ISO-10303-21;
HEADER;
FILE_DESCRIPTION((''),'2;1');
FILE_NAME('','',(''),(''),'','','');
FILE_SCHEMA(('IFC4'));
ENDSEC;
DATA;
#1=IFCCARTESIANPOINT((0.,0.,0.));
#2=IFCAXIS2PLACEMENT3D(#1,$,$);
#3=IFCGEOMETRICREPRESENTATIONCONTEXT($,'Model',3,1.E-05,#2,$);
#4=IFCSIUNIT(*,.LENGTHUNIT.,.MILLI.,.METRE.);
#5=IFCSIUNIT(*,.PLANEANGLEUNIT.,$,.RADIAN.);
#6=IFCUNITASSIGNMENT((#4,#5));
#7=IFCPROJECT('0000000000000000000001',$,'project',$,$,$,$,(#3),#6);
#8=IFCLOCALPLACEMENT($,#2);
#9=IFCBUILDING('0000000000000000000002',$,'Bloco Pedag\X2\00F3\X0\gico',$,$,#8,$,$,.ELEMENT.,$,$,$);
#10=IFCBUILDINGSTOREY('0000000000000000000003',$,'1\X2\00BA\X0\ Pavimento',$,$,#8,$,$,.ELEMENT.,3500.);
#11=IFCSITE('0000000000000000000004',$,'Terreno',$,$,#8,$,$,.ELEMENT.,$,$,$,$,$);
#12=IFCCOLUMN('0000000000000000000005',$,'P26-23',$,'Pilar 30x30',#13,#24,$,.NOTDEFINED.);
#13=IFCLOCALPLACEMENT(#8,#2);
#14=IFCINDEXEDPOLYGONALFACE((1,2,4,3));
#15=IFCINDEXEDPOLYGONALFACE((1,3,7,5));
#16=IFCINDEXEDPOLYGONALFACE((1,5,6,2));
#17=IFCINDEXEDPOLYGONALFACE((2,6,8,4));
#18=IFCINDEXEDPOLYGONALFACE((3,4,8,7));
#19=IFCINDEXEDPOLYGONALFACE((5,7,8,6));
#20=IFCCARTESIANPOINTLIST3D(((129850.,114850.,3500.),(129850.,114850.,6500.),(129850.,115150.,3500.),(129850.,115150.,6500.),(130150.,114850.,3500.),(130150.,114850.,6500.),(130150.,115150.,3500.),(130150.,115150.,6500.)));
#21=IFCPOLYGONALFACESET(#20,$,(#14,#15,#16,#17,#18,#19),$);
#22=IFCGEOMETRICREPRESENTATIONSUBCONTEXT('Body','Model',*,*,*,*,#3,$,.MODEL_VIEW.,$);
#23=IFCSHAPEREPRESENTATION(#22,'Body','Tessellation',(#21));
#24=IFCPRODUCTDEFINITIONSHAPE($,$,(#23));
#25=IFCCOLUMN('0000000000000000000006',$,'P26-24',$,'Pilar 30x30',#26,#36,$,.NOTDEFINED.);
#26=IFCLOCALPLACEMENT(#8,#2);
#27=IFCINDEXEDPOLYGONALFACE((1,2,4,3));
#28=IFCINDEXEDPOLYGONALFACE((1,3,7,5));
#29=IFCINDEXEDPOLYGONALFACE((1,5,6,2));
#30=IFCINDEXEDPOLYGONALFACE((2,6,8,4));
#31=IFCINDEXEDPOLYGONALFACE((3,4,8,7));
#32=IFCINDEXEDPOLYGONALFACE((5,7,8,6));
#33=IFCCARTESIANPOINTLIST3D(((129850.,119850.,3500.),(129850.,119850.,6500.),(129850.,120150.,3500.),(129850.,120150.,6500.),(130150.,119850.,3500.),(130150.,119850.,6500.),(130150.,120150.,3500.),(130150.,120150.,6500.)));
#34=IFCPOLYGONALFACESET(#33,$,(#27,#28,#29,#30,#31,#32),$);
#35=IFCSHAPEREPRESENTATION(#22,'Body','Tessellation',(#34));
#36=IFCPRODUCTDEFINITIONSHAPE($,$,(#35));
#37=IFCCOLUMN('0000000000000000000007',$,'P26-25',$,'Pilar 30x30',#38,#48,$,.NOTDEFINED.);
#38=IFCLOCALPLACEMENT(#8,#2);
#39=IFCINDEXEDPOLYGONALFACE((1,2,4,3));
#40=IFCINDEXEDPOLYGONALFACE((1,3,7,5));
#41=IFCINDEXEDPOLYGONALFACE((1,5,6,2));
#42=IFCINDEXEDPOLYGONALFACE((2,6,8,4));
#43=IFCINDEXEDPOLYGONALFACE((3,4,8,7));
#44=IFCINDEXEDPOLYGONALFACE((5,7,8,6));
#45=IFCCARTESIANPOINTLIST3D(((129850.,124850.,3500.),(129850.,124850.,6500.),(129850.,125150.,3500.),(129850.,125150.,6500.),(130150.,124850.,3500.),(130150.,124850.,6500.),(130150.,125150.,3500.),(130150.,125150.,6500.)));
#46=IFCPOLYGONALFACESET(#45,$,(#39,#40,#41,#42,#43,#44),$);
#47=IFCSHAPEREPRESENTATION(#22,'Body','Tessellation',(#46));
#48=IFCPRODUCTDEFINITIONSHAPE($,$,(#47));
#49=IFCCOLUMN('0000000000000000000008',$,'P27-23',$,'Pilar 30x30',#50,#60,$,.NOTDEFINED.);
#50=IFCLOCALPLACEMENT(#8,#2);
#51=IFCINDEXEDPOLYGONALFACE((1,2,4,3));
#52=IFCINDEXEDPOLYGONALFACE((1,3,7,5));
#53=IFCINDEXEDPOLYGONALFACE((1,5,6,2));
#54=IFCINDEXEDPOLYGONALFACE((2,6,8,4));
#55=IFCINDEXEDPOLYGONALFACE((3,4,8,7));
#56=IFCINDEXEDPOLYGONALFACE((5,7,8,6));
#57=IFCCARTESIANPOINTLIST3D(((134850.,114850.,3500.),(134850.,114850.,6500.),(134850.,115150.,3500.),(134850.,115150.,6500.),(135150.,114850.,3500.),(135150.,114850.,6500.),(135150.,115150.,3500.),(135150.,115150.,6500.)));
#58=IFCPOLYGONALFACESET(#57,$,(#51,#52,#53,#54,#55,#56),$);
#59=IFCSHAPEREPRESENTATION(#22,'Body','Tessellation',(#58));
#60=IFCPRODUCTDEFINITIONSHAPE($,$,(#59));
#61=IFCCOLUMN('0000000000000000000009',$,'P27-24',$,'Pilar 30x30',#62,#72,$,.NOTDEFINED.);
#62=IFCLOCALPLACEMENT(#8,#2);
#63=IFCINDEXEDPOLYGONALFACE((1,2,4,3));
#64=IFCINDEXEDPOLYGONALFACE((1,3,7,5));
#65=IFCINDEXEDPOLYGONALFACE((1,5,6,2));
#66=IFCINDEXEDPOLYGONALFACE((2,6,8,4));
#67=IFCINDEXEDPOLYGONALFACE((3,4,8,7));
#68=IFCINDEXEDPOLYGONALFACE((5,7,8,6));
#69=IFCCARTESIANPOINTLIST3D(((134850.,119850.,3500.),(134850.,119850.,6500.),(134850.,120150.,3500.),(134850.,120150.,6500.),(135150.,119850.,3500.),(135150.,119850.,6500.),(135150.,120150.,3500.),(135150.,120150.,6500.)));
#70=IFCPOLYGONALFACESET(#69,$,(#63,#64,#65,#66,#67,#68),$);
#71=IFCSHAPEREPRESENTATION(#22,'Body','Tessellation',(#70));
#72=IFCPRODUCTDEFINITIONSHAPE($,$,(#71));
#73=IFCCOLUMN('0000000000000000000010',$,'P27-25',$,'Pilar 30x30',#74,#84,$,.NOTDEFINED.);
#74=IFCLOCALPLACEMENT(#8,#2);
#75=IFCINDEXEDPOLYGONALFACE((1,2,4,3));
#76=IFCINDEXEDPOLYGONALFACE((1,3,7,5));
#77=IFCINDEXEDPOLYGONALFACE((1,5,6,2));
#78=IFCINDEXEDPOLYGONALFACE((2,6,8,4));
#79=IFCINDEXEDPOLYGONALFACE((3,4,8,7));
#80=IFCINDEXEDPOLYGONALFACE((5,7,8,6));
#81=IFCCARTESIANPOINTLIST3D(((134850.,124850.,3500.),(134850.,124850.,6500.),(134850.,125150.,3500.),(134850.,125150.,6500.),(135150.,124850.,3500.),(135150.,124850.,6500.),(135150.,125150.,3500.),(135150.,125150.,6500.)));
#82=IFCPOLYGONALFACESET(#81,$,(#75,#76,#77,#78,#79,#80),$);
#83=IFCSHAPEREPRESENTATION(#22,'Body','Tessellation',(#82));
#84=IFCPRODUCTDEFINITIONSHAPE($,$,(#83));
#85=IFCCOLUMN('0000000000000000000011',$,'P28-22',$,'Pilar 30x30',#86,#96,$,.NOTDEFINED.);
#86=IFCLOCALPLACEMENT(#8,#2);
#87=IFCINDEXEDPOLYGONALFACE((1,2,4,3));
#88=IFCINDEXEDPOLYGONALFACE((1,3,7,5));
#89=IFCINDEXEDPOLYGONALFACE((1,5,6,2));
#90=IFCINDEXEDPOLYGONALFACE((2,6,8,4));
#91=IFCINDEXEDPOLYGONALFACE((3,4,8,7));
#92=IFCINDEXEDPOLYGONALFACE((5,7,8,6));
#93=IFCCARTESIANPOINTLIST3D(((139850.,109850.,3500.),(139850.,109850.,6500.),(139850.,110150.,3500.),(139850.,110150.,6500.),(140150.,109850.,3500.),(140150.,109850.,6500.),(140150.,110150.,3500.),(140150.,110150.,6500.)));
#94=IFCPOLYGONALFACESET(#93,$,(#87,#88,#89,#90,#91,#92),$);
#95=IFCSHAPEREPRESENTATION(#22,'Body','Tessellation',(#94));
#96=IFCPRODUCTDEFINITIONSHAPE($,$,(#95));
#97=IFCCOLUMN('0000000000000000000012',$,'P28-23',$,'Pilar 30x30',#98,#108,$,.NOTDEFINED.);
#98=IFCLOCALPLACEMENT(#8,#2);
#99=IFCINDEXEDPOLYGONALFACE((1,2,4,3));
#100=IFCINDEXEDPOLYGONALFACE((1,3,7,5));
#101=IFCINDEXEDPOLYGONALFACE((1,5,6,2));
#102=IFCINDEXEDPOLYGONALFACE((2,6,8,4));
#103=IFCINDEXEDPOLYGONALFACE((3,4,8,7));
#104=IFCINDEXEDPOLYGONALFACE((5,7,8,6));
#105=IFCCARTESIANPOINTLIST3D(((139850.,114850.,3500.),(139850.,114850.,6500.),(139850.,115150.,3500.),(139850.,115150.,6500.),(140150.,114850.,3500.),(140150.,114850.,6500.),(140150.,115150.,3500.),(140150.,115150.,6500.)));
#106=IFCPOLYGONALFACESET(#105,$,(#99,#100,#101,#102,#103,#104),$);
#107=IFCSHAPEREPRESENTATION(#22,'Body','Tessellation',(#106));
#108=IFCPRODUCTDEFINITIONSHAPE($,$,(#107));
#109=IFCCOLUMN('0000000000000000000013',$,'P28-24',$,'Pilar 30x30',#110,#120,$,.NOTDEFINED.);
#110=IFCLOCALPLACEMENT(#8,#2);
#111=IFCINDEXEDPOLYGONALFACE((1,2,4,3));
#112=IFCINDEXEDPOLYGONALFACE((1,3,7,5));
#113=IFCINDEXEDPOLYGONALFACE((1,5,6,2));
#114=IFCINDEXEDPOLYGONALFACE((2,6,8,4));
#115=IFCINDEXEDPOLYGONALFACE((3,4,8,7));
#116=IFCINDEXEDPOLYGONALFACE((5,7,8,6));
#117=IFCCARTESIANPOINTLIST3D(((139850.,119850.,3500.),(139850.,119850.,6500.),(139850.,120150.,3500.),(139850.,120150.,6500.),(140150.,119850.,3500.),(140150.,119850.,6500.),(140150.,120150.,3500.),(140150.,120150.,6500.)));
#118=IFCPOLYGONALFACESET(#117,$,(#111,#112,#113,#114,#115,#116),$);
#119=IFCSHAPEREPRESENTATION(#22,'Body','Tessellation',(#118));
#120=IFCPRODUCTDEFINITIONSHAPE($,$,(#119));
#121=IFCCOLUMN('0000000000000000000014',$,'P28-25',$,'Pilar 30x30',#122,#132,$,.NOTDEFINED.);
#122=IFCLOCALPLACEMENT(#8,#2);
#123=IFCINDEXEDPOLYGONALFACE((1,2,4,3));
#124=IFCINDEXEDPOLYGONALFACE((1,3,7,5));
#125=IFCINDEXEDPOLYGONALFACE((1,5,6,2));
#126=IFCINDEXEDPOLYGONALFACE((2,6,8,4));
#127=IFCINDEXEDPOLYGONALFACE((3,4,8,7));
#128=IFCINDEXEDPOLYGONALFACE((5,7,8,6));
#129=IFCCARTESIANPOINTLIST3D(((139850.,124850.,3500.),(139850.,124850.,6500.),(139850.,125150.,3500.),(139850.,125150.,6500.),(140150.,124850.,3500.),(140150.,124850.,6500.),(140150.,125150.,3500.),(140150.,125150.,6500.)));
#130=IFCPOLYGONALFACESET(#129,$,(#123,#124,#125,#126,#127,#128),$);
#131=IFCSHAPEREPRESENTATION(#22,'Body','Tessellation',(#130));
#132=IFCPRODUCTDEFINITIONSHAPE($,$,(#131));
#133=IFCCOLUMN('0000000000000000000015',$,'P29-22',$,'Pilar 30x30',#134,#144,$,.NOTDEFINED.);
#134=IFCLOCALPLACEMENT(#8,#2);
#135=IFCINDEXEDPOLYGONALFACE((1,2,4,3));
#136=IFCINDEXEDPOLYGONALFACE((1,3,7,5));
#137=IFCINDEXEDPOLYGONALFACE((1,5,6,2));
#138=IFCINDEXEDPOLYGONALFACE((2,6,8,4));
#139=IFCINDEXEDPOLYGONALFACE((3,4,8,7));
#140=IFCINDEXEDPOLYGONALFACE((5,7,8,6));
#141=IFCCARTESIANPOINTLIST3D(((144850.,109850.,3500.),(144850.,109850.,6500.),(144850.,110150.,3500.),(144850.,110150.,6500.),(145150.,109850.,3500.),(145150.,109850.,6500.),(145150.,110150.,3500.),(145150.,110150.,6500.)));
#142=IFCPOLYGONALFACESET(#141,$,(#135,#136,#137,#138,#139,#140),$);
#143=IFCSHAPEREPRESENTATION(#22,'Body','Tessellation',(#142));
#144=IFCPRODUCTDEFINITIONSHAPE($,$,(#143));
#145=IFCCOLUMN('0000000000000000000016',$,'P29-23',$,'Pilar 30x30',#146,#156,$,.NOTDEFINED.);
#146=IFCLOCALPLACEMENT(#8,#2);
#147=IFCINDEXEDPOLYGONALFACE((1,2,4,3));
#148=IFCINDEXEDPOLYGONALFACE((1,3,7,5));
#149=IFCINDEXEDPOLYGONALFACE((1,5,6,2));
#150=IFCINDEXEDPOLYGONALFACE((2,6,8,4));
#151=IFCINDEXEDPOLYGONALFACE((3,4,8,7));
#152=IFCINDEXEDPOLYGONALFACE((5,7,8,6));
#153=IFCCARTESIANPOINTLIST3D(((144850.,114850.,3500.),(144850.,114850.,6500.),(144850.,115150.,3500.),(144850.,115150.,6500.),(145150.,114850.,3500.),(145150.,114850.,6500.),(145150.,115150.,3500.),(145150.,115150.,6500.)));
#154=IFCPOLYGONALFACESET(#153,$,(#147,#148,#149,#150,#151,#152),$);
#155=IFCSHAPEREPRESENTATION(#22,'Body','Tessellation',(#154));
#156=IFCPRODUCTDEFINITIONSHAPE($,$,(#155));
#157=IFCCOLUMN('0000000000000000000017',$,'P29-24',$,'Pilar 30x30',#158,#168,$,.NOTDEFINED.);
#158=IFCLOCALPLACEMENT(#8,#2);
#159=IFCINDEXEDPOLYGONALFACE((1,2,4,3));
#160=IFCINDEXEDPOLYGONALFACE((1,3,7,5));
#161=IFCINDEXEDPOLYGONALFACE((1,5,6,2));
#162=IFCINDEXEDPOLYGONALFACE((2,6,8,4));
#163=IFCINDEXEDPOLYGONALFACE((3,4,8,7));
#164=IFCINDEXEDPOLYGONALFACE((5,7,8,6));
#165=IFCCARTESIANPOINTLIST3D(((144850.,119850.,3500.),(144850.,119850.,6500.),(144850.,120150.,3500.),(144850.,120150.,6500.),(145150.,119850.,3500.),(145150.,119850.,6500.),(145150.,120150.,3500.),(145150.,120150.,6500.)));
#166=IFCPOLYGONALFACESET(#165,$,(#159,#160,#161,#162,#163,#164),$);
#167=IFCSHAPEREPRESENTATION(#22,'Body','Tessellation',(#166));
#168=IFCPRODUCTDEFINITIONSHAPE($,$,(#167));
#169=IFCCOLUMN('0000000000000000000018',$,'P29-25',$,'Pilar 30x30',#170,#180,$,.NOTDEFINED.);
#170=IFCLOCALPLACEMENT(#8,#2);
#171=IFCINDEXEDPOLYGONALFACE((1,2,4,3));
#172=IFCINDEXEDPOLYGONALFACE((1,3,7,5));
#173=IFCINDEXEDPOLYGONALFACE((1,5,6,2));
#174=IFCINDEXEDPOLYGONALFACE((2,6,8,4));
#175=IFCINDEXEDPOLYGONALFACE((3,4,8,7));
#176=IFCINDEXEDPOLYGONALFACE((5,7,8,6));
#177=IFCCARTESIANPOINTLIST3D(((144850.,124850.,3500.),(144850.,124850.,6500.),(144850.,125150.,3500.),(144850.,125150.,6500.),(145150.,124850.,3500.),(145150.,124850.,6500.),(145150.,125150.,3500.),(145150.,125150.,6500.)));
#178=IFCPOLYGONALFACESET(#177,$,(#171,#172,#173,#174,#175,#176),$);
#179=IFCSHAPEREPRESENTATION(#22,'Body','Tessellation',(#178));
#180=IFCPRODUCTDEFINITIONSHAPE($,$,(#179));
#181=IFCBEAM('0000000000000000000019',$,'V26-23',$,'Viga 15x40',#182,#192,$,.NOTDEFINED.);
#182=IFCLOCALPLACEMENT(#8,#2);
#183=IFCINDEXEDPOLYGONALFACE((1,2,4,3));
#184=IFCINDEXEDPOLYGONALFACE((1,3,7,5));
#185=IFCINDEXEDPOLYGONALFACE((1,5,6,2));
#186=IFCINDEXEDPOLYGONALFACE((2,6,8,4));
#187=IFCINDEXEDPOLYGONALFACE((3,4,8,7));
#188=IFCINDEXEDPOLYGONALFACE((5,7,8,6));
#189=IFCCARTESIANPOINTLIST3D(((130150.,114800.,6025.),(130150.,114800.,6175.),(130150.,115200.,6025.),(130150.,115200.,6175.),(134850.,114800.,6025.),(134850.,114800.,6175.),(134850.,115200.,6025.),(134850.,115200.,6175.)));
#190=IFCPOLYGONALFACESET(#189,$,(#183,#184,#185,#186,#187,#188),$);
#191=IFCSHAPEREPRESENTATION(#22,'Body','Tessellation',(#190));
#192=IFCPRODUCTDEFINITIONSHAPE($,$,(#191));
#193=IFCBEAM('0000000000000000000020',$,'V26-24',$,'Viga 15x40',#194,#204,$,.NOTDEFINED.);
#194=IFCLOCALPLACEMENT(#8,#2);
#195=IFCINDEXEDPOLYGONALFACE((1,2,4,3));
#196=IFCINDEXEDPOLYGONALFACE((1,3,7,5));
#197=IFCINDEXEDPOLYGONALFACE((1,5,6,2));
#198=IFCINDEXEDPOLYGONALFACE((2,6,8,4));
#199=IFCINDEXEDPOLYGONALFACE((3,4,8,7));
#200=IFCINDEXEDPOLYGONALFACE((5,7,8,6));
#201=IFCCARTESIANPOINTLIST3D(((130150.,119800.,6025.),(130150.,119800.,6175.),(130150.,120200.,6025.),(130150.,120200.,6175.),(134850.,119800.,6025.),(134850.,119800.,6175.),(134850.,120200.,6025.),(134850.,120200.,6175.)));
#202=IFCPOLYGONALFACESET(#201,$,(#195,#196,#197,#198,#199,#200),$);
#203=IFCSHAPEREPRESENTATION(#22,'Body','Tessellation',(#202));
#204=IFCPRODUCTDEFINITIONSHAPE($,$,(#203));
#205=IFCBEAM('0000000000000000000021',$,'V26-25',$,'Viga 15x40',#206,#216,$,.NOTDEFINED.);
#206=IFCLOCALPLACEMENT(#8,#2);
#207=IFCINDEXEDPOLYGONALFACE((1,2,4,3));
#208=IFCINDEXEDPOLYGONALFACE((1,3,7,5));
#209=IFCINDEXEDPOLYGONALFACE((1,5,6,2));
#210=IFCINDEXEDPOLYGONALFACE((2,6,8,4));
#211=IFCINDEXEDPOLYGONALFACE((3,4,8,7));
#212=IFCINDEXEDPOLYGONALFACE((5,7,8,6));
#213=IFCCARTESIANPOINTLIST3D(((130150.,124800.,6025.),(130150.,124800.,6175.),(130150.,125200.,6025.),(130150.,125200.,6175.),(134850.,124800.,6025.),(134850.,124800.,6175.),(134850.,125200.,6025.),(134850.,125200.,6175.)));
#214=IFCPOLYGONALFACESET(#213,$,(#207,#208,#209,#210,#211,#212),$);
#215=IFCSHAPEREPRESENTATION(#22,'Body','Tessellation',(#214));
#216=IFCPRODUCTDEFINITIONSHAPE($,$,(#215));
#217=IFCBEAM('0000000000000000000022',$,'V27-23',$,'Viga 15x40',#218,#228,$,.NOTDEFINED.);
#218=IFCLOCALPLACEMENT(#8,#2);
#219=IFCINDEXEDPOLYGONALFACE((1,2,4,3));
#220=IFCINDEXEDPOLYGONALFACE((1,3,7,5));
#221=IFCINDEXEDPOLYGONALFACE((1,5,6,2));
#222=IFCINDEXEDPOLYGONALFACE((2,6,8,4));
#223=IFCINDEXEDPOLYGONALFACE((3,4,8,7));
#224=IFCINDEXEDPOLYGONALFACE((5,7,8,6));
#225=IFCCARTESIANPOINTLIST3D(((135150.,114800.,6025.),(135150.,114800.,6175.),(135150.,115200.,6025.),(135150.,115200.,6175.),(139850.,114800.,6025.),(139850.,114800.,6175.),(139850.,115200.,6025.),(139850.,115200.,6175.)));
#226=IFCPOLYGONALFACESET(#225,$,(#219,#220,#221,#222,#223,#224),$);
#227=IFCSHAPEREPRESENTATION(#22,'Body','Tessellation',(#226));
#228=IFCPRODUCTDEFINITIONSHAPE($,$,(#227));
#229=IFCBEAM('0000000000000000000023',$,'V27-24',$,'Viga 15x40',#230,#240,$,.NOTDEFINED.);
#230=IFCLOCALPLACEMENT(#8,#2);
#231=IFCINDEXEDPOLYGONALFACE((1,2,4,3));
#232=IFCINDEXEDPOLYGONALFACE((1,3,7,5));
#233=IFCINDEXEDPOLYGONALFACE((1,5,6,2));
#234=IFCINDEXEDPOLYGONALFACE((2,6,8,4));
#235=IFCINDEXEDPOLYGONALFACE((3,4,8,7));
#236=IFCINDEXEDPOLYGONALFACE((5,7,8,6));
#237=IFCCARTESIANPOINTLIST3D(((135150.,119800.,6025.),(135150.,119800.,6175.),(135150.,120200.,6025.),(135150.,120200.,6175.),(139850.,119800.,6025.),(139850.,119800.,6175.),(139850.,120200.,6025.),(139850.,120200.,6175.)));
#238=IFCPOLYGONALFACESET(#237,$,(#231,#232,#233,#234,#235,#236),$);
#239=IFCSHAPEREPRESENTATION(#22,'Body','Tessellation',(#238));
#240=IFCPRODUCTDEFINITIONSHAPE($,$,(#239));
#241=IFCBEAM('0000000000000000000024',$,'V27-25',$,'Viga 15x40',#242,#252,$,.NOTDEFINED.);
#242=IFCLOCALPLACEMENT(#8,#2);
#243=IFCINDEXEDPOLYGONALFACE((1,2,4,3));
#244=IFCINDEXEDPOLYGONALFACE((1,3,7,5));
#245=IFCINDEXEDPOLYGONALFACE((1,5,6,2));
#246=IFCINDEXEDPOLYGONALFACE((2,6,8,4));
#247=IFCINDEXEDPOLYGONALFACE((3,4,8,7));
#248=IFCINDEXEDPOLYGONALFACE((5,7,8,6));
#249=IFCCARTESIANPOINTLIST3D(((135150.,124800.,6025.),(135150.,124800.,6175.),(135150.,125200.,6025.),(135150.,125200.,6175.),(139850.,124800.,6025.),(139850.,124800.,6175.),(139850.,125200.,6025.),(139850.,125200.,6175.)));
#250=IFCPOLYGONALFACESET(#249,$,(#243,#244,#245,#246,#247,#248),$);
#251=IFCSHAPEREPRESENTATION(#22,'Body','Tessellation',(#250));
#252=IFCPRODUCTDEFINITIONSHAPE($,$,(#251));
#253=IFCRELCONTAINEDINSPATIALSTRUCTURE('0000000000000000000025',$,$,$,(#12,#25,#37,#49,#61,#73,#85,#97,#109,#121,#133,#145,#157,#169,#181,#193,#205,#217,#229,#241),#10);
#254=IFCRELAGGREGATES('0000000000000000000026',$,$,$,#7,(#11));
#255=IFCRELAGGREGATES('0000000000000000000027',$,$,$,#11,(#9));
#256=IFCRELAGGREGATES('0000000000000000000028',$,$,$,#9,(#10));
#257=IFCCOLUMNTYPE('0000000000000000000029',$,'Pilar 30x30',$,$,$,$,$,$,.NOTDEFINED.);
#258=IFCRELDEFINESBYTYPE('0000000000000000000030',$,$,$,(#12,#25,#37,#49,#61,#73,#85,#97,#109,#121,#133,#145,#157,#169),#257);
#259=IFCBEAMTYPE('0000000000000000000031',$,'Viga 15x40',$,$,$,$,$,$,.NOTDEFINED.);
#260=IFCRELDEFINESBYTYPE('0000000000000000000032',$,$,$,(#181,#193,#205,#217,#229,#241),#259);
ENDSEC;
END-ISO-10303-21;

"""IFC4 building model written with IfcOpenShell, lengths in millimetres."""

from ifc_helpers import new_model, si_unit, frame, origin, origin_2d, place, context, subcontext, project, spatial, rectangle, extrude, type_object, element, save


model = new_model("IFC4")

# Units and contexts
model_context = context("Model", 3, precision=1e-05, world=origin())
body_context = subcontext(model_context, "Body", "Model", "MODEL_VIEW")
ifc_project = project(units=[si_unit("LENGTHUNIT", "METRE", prefix="MILLI"), si_unit("PLANEANGLEUNIT", "RADIAN")], contexts=[model_context])

# Site, building, storey
placement = place(None, origin())
site = spatial("IfcSite", under=ifc_project, at=placement, Name="Terreno", CompositionType="ELEMENT")
building = spatial("IfcBuilding", under=site, at=placement, Name="Bloco Pedagógico", CompositionType="ELEMENT")
storey = spatial("IfcBuildingStorey", under=building, at=placement, Name="1º Pavimento", CompositionType="ELEMENT", Elevation=3500.0)

# Columns
column_type = type_object("IfcColumnType", Name="Pilar 30x30", PredefinedType="NOTDEFINED")
for number, where, z_axis, x_axis, name in (
    (1, (130000.0, 115000.0, 3500.0), (0.0, 0.0, 1.0), (1.0, 0.0, 0.0), "P26-23"),
    (2, (130000.0, 120000.0, 3500.0), (0.0, 0.0, 1.0), (1.0, 0.0, 0.0), "P26-24"),
    (3, (130000.0, 125000.0, 3500.0), (0.0, 0.0, 1.0), (1.0, 0.0, 0.0), "P26-25"),
    (4, (135000.0, 115000.0, 3500.0), (0.0, 0.0, 1.0), (1.0, 0.0, 0.0), "P27-23"),
    (5, (135000.0, 120000.0, 3500.0), (0.0, 0.0, 1.0), (1.0, 0.0, 0.0), "P27-24"),
    (6, (135000.0, 125000.0, 3500.0), (0.0, 0.0, 1.0), (1.0, 0.0, 0.0), "P27-25"),
    (7, (140000.0, 110000.0, 3500.0), (0.0, 0.0, 1.0), (1.0, 0.0, 0.0), "P28-22"),
    (8, (140000.0, 115000.0, 3500.0), (0.0, 0.0, 1.0), (1.0, 0.0, 0.0), "P28-23"),
    (9, (140000.0, 120000.0, 3500.0), (0.0, 0.0, 1.0), (1.0, 0.0, 0.0), "P28-24"),
    (10, (140000.0, 125000.0, 3500.0), (0.0, 0.0, 1.0), (1.0, 0.0, 0.0), "P28-25"),
    (11, (145000.0, 110000.0, 3500.0), (0.0, 0.0, 1.0), (1.0, 0.0, 0.0), "P29-22"),
    (12, (145000.0, 115000.0, 3500.0), (0.0, 0.0, 1.0), (1.0, 0.0, 0.0), "P29-23"),
    (13, (145000.0, 120000.0, 3500.0), (0.0, 0.0, 1.0), (1.0, 0.0, 0.0), "P29-24"),
    (14, (145000.0, 125000.0, 3500.0), (0.0, 0.0, 1.0), (1.0, 0.0, 0.0), "P29-25"),
):
    element("IfcColumn", number, at=place(None, frame(where, z_axis=z_axis, x_axis=x_axis)), inside=storey, type_object=column_type, Name=name, ObjectType="Pilar 30x30", PredefinedType="NOTDEFINED", context=body_context, shape_type="SweptSolid", body=[
        extrude(rectangle(XDim=300.0, YDim=300.0, at=origin_2d()), None, (0.0, 0.0, 1.0), 3000.0),
    ])

# Beams
beam_type = type_object("IfcBeamType", Name="Viga 15x40", PredefinedType="NOTDEFINED")
for number, where, z_axis, x_axis, name in (
    (15, (130150.0, 115000.0, 6100.0), (1.0, 0.0, 0.0), (0.0, 1.0, 0.0), "V26-23"),
    (16, (130150.0, 120000.0, 6100.0), (1.0, 0.0, 0.0), (0.0, 1.0, 0.0), "V26-24"),
    (17, (130150.0, 125000.0, 6100.0), (1.0, 0.0, 0.0), (0.0, 1.0, 0.0), "V26-25"),
    (18, (135150.0, 115000.0, 6100.0), (1.0, 0.0, 0.0), (0.0, 1.0, 0.0), "V27-23"),
    (19, (135150.0, 120000.0, 6100.0), (1.0, 0.0, 0.0), (0.0, 1.0, 0.0), "V27-24"),
    (20, (135150.0, 125000.0, 6100.0), (1.0, 0.0, 0.0), (0.0, 1.0, 0.0), "V27-25"),
):
    element("IfcBeam", number, at=place(None, frame(where, z_axis=z_axis, x_axis=x_axis)), inside=storey, type_object=beam_type, Name=name, ObjectType="Viga 15x40", PredefinedType="NOTDEFINED", context=body_context, shape_type="SweptSolid", body=[
        extrude(rectangle(XDim=400.0, YDim=150.0, at=origin_2d()), None, (0.0, 0.0, 1.0), 4700.0),
    ])

save(model, "model.ifc")
